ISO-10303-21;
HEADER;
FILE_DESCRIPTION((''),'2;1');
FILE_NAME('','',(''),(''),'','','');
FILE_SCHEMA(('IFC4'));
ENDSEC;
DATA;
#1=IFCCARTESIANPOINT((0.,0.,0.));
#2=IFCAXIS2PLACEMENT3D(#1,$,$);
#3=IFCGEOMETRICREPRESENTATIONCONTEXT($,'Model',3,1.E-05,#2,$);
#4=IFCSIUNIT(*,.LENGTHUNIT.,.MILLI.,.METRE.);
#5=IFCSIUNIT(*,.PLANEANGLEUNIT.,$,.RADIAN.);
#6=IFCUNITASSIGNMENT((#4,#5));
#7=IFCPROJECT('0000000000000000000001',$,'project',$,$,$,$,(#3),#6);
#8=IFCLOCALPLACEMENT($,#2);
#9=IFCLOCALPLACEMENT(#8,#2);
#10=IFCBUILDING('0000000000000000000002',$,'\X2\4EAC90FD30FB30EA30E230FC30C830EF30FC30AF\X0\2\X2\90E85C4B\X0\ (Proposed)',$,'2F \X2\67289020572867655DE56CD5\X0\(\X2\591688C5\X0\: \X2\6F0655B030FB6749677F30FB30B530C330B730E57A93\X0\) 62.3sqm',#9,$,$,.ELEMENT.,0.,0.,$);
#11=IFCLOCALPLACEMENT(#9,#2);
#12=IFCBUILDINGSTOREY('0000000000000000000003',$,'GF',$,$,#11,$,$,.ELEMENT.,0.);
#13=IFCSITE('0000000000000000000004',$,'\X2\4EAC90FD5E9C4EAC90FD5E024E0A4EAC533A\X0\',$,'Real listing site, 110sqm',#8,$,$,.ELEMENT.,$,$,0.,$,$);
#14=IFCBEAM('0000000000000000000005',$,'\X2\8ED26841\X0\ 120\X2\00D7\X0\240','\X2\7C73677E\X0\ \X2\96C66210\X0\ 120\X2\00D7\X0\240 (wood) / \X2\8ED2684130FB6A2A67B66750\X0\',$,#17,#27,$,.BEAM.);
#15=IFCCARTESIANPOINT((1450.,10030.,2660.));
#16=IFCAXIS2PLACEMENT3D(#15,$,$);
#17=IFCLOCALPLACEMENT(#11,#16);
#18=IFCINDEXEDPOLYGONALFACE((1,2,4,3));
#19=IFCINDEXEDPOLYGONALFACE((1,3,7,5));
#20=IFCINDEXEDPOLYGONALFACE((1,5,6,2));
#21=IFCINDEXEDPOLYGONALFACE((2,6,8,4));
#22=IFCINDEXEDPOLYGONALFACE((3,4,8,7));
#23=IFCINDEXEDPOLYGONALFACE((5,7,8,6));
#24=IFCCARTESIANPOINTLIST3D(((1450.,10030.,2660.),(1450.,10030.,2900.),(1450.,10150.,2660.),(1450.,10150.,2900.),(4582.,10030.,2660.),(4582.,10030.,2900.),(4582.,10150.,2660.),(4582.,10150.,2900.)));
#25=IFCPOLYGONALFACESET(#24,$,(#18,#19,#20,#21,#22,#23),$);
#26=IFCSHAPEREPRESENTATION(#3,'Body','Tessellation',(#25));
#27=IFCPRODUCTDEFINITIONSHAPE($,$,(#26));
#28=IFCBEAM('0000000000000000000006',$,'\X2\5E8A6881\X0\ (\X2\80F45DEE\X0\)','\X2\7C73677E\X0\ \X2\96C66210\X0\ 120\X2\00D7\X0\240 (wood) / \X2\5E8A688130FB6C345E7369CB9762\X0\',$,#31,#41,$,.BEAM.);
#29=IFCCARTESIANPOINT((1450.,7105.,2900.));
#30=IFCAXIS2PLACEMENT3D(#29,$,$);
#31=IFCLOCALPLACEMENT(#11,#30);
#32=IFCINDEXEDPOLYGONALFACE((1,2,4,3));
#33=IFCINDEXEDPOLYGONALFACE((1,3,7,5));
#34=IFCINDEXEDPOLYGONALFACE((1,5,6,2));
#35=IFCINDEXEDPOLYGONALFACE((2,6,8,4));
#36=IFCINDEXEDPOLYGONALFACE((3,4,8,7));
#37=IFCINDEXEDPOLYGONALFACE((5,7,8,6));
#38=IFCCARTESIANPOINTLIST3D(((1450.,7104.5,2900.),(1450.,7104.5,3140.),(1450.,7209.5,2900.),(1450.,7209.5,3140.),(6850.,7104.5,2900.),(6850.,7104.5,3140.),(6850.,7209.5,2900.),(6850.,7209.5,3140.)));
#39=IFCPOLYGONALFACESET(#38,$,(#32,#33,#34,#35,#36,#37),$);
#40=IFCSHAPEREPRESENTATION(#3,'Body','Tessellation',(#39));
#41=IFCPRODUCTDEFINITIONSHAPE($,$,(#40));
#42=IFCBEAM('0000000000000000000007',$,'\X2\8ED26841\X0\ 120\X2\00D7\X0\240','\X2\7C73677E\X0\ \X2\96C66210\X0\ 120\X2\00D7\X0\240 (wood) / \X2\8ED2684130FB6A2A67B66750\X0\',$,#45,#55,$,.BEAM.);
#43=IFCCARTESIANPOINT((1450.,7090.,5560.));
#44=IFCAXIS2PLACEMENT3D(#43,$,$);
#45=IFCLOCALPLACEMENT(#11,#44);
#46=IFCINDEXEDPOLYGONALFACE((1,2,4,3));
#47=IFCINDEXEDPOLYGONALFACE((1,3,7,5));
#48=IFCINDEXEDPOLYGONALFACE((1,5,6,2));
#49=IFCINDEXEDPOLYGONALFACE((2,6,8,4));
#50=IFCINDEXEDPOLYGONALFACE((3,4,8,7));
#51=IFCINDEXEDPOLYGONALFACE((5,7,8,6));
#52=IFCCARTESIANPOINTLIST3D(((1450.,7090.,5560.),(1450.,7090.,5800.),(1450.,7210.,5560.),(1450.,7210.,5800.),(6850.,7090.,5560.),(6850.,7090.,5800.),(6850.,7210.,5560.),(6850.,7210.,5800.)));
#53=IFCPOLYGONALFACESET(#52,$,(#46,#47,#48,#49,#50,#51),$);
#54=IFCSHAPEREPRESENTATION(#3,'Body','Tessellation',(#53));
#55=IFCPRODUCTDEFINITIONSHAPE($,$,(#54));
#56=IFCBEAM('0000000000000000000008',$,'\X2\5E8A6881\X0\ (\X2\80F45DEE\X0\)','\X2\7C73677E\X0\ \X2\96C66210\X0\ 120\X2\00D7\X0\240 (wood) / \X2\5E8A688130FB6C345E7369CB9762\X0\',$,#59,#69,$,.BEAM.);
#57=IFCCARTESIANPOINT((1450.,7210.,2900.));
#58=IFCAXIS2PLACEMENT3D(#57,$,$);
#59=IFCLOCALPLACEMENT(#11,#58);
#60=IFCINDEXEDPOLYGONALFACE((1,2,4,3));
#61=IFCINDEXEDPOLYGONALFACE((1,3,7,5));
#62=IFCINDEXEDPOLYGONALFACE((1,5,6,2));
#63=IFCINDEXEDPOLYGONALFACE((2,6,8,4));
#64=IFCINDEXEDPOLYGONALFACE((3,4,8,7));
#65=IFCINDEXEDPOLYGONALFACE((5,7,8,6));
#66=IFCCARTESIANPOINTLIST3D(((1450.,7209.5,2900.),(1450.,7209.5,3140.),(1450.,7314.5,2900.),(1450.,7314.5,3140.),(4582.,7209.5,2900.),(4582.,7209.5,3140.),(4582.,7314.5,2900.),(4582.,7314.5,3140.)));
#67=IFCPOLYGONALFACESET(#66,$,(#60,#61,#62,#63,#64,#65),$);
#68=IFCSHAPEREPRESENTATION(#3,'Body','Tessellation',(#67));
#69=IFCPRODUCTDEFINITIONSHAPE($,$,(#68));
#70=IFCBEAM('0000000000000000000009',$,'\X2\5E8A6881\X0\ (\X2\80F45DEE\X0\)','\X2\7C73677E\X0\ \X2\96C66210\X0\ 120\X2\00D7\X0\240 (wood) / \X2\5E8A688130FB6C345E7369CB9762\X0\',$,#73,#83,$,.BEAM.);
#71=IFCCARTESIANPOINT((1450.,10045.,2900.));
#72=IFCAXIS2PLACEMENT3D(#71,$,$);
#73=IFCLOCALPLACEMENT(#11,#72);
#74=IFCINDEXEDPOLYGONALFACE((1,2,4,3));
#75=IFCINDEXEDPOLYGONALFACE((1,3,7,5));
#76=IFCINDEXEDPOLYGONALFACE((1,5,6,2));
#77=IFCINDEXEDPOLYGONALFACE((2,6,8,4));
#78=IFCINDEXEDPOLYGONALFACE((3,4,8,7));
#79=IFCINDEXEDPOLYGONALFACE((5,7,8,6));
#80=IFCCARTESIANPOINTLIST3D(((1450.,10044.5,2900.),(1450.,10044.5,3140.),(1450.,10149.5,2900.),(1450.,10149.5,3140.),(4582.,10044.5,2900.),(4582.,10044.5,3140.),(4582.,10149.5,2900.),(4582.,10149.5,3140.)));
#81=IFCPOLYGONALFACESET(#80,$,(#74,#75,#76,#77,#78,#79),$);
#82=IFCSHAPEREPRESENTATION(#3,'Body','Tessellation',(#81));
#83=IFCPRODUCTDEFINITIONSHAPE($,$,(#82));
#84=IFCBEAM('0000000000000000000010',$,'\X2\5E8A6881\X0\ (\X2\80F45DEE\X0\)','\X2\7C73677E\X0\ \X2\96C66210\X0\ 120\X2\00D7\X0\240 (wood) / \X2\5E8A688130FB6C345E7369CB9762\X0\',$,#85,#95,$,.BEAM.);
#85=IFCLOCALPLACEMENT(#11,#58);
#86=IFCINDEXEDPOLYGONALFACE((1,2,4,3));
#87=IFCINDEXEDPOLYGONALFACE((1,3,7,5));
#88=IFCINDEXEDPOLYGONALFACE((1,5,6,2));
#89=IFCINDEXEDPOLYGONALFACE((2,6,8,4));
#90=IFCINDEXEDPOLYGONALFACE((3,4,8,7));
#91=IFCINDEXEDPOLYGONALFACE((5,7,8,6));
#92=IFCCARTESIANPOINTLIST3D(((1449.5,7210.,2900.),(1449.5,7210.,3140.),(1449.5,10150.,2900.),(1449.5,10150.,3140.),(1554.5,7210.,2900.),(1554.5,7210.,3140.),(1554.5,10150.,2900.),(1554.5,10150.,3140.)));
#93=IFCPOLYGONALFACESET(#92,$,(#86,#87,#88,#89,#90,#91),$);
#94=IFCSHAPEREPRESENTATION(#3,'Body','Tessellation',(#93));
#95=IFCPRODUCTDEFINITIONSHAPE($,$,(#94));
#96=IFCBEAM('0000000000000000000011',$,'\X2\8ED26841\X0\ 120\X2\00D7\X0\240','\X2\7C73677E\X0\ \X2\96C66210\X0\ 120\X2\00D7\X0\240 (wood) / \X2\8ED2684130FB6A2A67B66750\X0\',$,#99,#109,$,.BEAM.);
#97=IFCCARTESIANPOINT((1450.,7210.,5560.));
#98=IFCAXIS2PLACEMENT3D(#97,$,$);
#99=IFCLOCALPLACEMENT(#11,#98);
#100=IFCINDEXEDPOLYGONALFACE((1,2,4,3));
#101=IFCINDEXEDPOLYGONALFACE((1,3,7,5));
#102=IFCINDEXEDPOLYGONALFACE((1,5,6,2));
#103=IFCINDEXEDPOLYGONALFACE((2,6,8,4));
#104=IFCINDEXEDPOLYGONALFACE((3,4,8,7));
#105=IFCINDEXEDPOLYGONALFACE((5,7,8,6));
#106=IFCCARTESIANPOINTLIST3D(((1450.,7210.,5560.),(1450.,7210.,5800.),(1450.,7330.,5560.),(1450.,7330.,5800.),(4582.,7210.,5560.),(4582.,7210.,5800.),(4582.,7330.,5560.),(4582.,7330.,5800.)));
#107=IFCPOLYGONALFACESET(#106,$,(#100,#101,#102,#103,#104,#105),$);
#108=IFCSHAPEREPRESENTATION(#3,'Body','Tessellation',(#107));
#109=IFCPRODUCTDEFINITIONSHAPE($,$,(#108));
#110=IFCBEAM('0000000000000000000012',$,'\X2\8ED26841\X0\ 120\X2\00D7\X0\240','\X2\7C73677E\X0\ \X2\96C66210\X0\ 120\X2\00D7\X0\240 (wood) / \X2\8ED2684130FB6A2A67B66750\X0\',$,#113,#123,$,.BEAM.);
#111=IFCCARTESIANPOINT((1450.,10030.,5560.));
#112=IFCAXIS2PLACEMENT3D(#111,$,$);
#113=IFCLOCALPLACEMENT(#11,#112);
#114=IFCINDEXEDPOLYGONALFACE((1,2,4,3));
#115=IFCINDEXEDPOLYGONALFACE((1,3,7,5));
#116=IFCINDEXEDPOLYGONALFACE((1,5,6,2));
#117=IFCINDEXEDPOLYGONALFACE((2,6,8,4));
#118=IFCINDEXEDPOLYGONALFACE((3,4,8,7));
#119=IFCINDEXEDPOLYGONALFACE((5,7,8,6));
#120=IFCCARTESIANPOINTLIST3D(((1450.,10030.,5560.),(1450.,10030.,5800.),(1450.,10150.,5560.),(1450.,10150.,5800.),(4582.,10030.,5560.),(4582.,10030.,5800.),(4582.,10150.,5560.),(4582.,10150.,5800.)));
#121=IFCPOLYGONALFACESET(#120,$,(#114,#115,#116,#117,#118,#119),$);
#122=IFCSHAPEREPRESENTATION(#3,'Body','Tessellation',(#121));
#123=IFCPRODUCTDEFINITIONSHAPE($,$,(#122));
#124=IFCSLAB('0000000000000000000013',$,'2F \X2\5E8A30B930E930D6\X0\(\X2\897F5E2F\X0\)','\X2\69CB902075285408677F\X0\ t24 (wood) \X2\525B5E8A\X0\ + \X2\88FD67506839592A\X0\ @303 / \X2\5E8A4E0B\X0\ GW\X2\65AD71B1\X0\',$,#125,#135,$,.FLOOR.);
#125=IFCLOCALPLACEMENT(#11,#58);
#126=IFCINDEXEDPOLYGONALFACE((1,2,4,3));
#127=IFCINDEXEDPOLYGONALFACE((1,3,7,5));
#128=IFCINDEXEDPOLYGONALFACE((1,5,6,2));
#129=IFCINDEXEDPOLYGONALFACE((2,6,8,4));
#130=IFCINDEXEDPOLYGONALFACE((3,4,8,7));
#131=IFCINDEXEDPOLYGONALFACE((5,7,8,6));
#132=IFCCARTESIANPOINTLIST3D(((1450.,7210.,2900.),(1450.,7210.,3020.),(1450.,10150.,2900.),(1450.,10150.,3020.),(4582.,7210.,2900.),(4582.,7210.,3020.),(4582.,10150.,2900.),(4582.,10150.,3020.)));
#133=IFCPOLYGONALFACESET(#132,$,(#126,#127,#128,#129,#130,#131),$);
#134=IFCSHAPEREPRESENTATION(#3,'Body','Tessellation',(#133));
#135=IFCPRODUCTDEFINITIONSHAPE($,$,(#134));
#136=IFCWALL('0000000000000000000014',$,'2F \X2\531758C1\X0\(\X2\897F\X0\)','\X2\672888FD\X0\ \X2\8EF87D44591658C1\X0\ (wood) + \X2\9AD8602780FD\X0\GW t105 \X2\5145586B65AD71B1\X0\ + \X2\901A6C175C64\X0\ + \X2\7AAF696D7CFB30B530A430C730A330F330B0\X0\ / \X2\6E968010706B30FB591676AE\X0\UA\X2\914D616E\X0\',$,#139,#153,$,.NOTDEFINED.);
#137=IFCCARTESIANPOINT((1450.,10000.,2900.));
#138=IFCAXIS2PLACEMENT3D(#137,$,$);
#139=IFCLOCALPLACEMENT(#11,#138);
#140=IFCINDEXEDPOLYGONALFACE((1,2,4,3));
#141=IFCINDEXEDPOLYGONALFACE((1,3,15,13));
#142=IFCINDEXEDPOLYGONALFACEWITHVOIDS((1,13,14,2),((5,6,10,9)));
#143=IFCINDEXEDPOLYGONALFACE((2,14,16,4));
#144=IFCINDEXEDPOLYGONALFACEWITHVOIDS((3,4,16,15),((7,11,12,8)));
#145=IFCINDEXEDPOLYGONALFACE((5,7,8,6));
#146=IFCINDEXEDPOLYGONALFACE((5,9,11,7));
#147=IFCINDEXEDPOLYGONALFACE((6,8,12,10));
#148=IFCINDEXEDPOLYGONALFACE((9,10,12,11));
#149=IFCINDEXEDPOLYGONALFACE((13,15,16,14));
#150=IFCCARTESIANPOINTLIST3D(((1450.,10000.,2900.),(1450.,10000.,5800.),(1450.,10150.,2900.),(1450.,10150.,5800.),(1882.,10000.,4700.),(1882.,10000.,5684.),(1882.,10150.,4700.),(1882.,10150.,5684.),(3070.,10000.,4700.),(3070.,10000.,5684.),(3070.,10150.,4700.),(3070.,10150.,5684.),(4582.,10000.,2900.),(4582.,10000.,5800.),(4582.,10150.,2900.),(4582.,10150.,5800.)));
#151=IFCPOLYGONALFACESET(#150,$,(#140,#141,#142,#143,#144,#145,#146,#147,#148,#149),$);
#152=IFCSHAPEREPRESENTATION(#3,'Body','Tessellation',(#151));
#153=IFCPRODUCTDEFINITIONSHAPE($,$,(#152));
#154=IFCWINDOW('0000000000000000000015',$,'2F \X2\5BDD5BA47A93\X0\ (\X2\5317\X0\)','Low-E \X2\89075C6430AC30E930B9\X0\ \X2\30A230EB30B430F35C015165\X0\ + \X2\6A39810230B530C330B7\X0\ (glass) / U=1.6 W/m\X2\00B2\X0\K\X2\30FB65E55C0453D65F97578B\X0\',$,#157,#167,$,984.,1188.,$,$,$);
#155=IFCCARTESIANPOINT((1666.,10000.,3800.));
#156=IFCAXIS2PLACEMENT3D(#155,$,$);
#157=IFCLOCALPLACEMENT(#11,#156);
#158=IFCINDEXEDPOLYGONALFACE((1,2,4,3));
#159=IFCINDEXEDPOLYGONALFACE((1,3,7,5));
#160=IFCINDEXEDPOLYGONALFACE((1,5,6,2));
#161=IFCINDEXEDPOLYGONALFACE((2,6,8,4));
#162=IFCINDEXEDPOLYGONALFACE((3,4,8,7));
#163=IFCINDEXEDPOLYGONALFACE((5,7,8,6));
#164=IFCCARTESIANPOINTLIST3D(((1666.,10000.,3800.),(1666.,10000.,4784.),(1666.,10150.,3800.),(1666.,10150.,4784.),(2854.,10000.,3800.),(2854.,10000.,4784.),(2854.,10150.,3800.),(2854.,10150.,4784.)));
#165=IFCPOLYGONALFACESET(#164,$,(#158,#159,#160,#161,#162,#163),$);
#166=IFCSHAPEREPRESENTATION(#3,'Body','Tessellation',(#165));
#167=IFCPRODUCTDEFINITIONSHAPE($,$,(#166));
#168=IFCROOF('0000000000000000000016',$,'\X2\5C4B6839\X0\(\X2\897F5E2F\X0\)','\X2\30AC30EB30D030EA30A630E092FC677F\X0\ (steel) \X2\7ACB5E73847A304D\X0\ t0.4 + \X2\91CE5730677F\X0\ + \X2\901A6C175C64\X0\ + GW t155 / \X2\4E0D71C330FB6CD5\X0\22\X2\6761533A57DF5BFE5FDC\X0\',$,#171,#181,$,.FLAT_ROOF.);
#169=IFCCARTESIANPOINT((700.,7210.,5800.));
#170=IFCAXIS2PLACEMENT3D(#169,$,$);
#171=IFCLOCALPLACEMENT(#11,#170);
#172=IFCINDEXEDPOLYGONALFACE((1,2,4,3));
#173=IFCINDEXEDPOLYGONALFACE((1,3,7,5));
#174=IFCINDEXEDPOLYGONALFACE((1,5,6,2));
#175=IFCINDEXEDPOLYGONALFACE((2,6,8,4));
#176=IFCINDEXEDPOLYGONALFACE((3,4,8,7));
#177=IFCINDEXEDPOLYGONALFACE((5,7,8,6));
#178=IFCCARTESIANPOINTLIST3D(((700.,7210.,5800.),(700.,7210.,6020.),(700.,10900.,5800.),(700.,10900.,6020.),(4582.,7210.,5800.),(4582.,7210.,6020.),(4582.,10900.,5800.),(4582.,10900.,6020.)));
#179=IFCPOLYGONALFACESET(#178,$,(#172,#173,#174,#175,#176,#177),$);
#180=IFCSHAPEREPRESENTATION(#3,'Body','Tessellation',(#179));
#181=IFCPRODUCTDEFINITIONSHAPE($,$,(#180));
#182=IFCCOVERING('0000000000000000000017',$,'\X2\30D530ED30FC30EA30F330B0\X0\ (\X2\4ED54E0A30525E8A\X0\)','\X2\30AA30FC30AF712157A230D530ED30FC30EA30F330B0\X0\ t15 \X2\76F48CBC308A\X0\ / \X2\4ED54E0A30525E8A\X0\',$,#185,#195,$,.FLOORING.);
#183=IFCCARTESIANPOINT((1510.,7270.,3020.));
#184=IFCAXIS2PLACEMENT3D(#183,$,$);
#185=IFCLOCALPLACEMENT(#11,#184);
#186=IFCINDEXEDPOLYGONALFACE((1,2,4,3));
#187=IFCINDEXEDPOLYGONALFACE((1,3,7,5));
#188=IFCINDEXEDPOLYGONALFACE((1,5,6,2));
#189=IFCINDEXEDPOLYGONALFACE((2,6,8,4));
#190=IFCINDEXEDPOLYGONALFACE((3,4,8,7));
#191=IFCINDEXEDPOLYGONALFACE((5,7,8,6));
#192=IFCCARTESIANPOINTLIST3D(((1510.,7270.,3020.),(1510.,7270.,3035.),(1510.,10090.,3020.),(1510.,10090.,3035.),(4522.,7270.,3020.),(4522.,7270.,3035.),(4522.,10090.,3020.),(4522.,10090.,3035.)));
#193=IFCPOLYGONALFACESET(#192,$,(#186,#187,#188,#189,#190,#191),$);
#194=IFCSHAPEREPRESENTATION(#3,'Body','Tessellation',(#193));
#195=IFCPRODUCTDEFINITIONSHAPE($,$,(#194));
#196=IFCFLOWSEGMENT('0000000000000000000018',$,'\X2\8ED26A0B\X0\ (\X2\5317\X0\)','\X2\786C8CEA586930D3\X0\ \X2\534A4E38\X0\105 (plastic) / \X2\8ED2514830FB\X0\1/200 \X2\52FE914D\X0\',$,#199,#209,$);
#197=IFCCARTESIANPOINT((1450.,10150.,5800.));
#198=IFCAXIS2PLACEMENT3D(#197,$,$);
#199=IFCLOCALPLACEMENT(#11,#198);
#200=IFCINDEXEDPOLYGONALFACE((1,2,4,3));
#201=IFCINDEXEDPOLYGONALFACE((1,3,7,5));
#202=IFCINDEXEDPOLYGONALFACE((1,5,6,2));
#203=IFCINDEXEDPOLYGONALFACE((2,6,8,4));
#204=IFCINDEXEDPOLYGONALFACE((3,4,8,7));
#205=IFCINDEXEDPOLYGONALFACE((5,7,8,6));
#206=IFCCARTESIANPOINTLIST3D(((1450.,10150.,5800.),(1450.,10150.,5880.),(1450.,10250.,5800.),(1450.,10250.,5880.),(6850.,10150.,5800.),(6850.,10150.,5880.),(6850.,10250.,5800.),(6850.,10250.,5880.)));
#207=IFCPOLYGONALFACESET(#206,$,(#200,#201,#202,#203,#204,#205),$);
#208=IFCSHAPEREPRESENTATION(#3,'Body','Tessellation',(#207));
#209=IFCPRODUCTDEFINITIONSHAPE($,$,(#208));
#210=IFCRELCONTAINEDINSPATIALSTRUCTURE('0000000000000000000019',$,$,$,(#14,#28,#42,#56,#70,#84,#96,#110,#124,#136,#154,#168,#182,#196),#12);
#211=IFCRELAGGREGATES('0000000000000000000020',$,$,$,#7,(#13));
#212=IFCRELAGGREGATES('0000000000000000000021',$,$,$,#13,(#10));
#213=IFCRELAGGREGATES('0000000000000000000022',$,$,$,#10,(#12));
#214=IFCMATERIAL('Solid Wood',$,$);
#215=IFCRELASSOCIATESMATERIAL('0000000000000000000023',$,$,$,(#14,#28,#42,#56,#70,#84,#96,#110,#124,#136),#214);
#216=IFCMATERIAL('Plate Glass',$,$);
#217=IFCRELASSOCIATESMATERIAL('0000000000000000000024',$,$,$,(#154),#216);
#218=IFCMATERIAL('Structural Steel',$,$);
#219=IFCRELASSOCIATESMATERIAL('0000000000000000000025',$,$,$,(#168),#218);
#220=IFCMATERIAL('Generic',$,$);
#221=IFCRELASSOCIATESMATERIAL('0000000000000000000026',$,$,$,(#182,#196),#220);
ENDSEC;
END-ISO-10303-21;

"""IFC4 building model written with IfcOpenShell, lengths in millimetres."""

from ifc_helpers import new_model, si_unit, frame, frame_2d, origin, place, context, project, spatial, rectangle, extrude, material, element, fill, save


model = new_model("IFC4")

# Units and contexts
model_context = context("Model", 3, precision=1e-05, world=origin())
ifc_project = project(units=[si_unit("LENGTHUNIT", "METRE", prefix="MILLI"), si_unit("PLANEANGLEUNIT", "RADIAN")], contexts=[model_context])

# Site, building, storey
site_placement = place(None, origin())
site = spatial("IfcSite", under=ifc_project, at=site_placement, Name="京都府京都市上京区", ObjectType="Real listing site, 110sqm", CompositionType="ELEMENT", RefElevation=0.0)
building_placement = place(site_placement, origin())
building = spatial("IfcBuilding", under=site, at=building_placement, Name="京都・リモートワーク2部屋 (Proposed)", ObjectType="2F 木造在来工法(外装: 漆喰・杉板・サッシュ窓) 62.3sqm", CompositionType="ELEMENT", ElevationOfRefHeight=0.0, ElevationOfTerrain=0.0)
storey_placement = place(building_placement, origin())
storey = spatial("IfcBuildingStorey", under=building, at=storey_placement, Name="GF", CompositionType="ELEMENT", Elevation=0.0)

# Shared definitions
ifc_material_1 = material(Name="Solid Wood")

# Beams
beam_1_placement = place(storey_placement, frame((1450.0, 10030.0, 2660.0)))
element("IfcBeam", 1, at=beam_1_placement, inside=storey, material=ifc_material_1, Name="軒桁 120×240", Description="米松 集成 120×240 (wood) / 軒桁・横架材", PredefinedType="BEAM", context=model_context, shape_type="SweptSolid", body=[
    extrude(rectangle(XDim=3132.0, YDim=120.0, at=frame_2d((1566.0, 60.0))), frame((1450.0, 10030.0, 2660.0)), (0.0, 0.0, 1.0), 240.0),
])
beam_2_placement = place(storey_placement, frame((1450.0, 7105.0, 2900.0)))
element("IfcBeam", 2, at=beam_2_placement, inside=storey, material=ifc_material_1, Name="床梁 (胴差)", Description="米松 集成 120×240 (wood) / 床梁・水平構面", PredefinedType="BEAM", context=model_context, shape_type="SweptSolid", body=[
    extrude(rectangle(XDim=5400.0, YDim=105.0, at=frame_2d((2700.0, 52.0))), frame((1450.0, 7105.0, 2900.0)), (0.0, 0.0, 1.0), 240.0),
])
beam_3_placement = place(storey_placement, frame((1450.0, 7090.0, 5560.0)))
element("IfcBeam", 3, at=beam_3_placement, inside=storey, material=ifc_material_1, Name="軒桁 120×240", Description="米松 集成 120×240 (wood) / 軒桁・横架材", PredefinedType="BEAM", context=model_context, shape_type="SweptSolid", body=[
    extrude(rectangle(XDim=5400.0, YDim=120.0, at=frame_2d((2700.0, 60.0))), frame((1450.0, 7090.0, 5560.0)), (0.0, 0.0, 1.0), 240.0),
])
beam_4_placement = place(storey_placement, frame((1450.0, 7210.0, 2900.0)))
element("IfcBeam", 4, at=beam_4_placement, inside=storey, material=ifc_material_1, Name="床梁 (胴差)", Description="米松 集成 120×240 (wood) / 床梁・水平構面", PredefinedType="BEAM", context=model_context, shape_type="SweptSolid", body=[
    extrude(rectangle(XDim=3132.0, YDim=105.0, at=frame_2d((1566.0, 52.0))), frame((1450.0, 7210.0, 2900.0)), (0.0, 0.0, 1.0), 240.0),
])
beam_5_placement = place(storey_placement, frame((1450.0, 10045.0, 2900.0)))
element("IfcBeam", 5, at=beam_5_placement, inside=storey, material=ifc_material_1, Name="床梁 (胴差)", Description="米松 集成 120×240 (wood) / 床梁・水平構面", PredefinedType="BEAM", context=model_context, shape_type="SweptSolid", body=[
    extrude(rectangle(XDim=3132.0, YDim=105.0, at=frame_2d((1566.0, 52.0))), frame((1450.0, 10045.0, 2900.0)), (0.0, 0.0, 1.0), 240.0),
])
beam_6_placement = place(storey_placement, frame((1450.0, 7210.0, 2900.0)))
element("IfcBeam", 6, at=beam_6_placement, inside=storey, material=ifc_material_1, Name="床梁 (胴差)", Description="米松 集成 120×240 (wood) / 床梁・水平構面", PredefinedType="BEAM", context=model_context, shape_type="SweptSolid", body=[
    extrude(rectangle(XDim=105.0, YDim=2940.0, at=frame_2d((52.0, 1470.0))), frame((1450.0, 7210.0, 2900.0)), (0.0, 0.0, 1.0), 240.0),
])
beam_7_placement = place(storey_placement, frame((1450.0, 7210.0, 5560.0)))
element("IfcBeam", 7, at=beam_7_placement, inside=storey, material=ifc_material_1, Name="軒桁 120×240", Description="米松 集成 120×240 (wood) / 軒桁・横架材", PredefinedType="BEAM", context=model_context, shape_type="SweptSolid", body=[
    extrude(rectangle(XDim=3132.0, YDim=120.0, at=frame_2d((1566.0, 60.0))), frame((1450.0, 7210.0, 5560.0)), (0.0, 0.0, 1.0), 240.0),
])
beam_8_placement = place(storey_placement, frame((1450.0, 10030.0, 5560.0)))
element("IfcBeam", 8, at=beam_8_placement, inside=storey, material=ifc_material_1, Name="軒桁 120×240", Description="米松 集成 120×240 (wood) / 軒桁・横架材", PredefinedType="BEAM", context=model_context, shape_type="SweptSolid", body=[
    extrude(rectangle(XDim=3132.0, YDim=120.0, at=frame_2d((1566.0, 60.0))), frame((1450.0, 10030.0, 5560.0)), (0.0, 0.0, 1.0), 240.0),
])

# Slab
slab_placement = place(storey_placement, frame((1450.0, 7210.0, 2900.0)))
element("IfcSlab", 9, at=slab_placement, inside=storey, material=ifc_material_1, Name="2F 床スラブ(西帯)", Description="構造用合板 t24 (wood) 剛床 + 製材根太 @303 / 床下 GW断熱", PredefinedType="FLOOR", context=model_context, shape_type="SweptSolid", body=[
    extrude(rectangle(XDim=3132.0, YDim=2940.0, at=frame_2d((1566.0, 1470.0))), frame((1450.0, 7210.0, 2900.0)), (0.0, 0.0, 1.0), 120.0),
])

# Wall, opening, window
wall_1_placement = place(storey_placement, frame((1450.0, 10000.0, 2900.0)))
wall_1 = element("IfcWall", 10, at=wall_1_placement, inside=storey, material=ifc_material_1, Name="2F 北壁(西)", Description="木製 軸組外壁 (wood) + 高性能GW t105 充填断熱 + 通気層 + 窯業系サイディング / 準耐火・外皮UA配慮", PredefinedType="NOTDEFINED", context=model_context, shape_type="SweptSolid", body=[
    extrude(rectangle(XDim=3132.0, YDim=150.0, at=frame_2d((1566.0, 75.0))), frame((1450.0, 10000.0, 2900.0)), (0.0, 0.0, 1.0), 2900.0),
])
opening_placement = place(storey_placement, frame((1666.0, 10000.0, 3800.0)))
opening = element("IfcOpeningElement", 11, at=opening_placement, cuts=wall_1, PredefinedType="NOTDEFINED", context=model_context, shape_type="SweptSolid", body=[
    extrude(rectangle(XDim=1188.0, YDim=150.0, at=frame_2d((594.0, 75.0))), frame((1666.0, 10000.0, 3800.0)), (0.0, 0.0, 1.0), 984.0),
])
ifc_material_2 = material(Name="Plate Glass")
window_placement = place(storey_placement, frame((1666.0, 10000.0, 3800.0)))
window = element("IfcWindow", 12, at=window_placement, inside=storey, material=ifc_material_2, Name="2F 寝室窓 (北)", Description="Low-E 複層ガラス アルゴン封入 + 樹脂サッシ (glass) / U=1.6 W/m²K・日射取得型", OverallHeight=984.0, OverallWidth=1188.0, context=model_context, shape_type="SweptSolid", body=[
    extrude(rectangle(XDim=1188.0, YDim=150.0, at=frame_2d((594.0, 75.0))), frame((1666.0, 10000.0, 3800.0)), (0.0, 0.0, 1.0), 984.0),
])
fill(opening, window)

# Roof
ifc_material_3 = material(Name="Structural Steel")
for number, where, name in (
    (13, (700.0, 7210.0, 5800.0), "屋根(西帯)"),
):
    element("IfcRoof", number, at=place(storey_placement, frame(where)), inside=storey, material=ifc_material_3, Name=name, Description="ガルバリウム鋼板 (steel) 立平葺き t0.4 + 野地板 + 通気層 + GW t155 / 不燃・法22条区域対応", PredefinedType="FLAT_ROOF", context=model_context, shape_type="SweptSolid", body=[
        extrude(rectangle(XDim=3882.0, YDim=3690.0, at=frame_2d((1941.0, 1845.0))), frame((700.0, 7210.0, 5800.0)), (0.0, 0.0, 1.0), 220.0),
    ])

# Covering
ifc_material_4 = material(Name="Generic")
covering_placement = place(storey_placement, frame((1510.0, 7270.0, 3020.0)))
element("IfcCovering", 14, at=covering_placement, inside=storey, material=ifc_material_4, Name="フローリング (仕上げ床)", Description="オーク無垢フローリング t15 直貼り / 仕上げ床", PredefinedType="FLOORING", context=model_context, shape_type="SweptSolid", body=[
    extrude(rectangle(XDim=3012.0, YDim=2820.0, at=frame_2d((1506.0, 1410.0))), frame((1510.0, 7270.0, 3020.0)), (0.0, 0.0, 1.0), 15.0),
])

# Flow segment
flow_segment_placement = place(storey_placement, frame((1450.0, 10150.0, 5800.0)))
element("IfcFlowSegment", 15, at=flow_segment_placement, inside=storey, material=ifc_material_4, Name="軒樋 (北)", Description="硬質塩ビ 半丸105 (plastic) / 軒先・1/200 勾配", context=model_context, shape_type="SweptSolid", body=[
    extrude(rectangle(XDim=5400.0, YDim=100.0, at=frame_2d((2700.0, 50.0))), frame((1450.0, 10150.0, 5800.0)), (0.0, 0.0, 1.0), 80.0),
])

save(model, "model.ifc")
